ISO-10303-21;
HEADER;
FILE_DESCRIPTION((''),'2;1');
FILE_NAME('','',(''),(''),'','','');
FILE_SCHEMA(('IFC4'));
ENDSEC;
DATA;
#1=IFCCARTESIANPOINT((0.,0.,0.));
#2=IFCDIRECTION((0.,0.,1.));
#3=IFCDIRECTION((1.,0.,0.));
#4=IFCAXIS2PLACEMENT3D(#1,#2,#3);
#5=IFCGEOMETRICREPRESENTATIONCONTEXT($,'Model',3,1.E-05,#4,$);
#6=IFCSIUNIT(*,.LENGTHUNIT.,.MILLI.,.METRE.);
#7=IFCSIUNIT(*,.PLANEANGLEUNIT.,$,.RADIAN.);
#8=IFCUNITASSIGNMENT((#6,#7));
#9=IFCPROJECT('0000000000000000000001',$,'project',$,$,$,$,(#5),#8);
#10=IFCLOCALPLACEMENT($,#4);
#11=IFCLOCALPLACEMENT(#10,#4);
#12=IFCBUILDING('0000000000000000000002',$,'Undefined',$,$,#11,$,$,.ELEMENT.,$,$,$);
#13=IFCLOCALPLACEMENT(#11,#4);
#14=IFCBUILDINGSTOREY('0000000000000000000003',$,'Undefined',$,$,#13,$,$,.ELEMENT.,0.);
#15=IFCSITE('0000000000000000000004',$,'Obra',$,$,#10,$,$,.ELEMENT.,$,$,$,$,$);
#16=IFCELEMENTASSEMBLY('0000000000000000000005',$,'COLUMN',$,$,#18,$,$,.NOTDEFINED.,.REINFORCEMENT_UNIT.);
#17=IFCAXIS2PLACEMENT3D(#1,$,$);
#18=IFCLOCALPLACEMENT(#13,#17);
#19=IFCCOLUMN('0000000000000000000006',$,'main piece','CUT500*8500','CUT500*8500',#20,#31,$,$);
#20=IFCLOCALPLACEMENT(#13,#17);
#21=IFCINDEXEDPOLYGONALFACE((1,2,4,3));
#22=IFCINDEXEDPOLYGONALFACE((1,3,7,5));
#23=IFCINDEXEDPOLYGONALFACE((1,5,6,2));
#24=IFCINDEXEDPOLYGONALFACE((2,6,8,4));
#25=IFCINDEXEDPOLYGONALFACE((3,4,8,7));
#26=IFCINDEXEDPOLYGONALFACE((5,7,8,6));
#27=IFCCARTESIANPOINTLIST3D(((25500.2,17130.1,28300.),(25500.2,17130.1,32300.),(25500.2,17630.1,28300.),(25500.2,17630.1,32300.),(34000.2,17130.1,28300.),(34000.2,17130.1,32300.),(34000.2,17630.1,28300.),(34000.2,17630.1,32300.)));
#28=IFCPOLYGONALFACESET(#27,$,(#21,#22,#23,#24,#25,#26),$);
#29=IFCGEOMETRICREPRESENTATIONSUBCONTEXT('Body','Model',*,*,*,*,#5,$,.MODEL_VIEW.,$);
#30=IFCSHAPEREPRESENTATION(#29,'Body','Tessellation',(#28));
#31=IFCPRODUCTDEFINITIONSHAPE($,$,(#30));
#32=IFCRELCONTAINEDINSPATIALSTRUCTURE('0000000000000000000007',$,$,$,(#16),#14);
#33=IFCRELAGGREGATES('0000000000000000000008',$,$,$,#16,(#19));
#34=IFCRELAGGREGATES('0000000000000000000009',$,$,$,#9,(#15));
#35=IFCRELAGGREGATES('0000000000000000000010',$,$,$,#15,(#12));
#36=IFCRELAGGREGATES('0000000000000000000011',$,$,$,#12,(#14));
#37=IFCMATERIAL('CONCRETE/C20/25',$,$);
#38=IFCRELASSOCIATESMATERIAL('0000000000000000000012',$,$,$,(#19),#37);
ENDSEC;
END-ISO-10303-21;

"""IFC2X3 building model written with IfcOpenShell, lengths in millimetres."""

from ifc_helpers import new_model, si_unit, frame, origin_with_axes, origin_2d_with_axis, place, context, subcontext, project, spatial, rectangle, extrude, material, element, aggregate, save


model = new_model("IFC2X3")

# Units and contexts
model_context = context("Model", 3, precision=1e-05, world=origin_with_axes())
body_context = subcontext(model_context, "Body", "Model", "MODEL_VIEW")
ifc_project = project(units=[si_unit("LENGTHUNIT", "METRE", prefix="MILLI"), si_unit("PLANEANGLEUNIT", "RADIAN")], contexts=[model_context])

# Site, building, storey
site_placement = place(None, origin_with_axes())
site = spatial("IfcSite", under=ifc_project, at=site_placement, Name="Obra", CompositionType="ELEMENT")
building_placement = place(site_placement, origin_with_axes())
building = spatial("IfcBuilding", under=site, at=building_placement, Name="Undefined", CompositionType="ELEMENT")
storey_placement = place(building_placement, origin_with_axes())
storey = spatial("IfcBuildingStorey", under=building, at=storey_placement, Name="Undefined", CompositionType="ELEMENT", Elevation=0.0)

# Element assembly, column
assembly_1_placement = place(storey_placement, origin_with_axes())
assembly_1 = element("IfcElementAssembly", 1, at=assembly_1_placement, inside=storey, Name="COLUMN", AssemblyPlace="NOTDEFINED", PredefinedType="REINFORCEMENT_UNIT")
ifc_material_1 = material(Name="CONCRETE/C20/25")
column_placement = place(assembly_1_placement, frame((29750.2, 17380.1, 28300.0), z_axis=(0.0, 0.0, 1.0), x_axis=(-1.0, 0.0, 0.0)))
column = element("IfcColumn", 2, at=column_placement, material=ifc_material_1, Name="main piece", Description="CUT500*8500", ObjectType="CUT500*8500", context=body_context, shape_type="SweptSolid", body=[
    extrude(rectangle(XDim=500.0, YDim=8500.0, at=origin_2d_with_axis()), frame((0.0, 0.0, 4000.0), z_axis=(0.0, 0.0, -1.0), x_axis=(0.0, 1.0, 0.0)), (0.0, 0.0, 1.0), 4000.0),
])
aggregate(assembly_1, [column])

save(model, "model.ifc")
